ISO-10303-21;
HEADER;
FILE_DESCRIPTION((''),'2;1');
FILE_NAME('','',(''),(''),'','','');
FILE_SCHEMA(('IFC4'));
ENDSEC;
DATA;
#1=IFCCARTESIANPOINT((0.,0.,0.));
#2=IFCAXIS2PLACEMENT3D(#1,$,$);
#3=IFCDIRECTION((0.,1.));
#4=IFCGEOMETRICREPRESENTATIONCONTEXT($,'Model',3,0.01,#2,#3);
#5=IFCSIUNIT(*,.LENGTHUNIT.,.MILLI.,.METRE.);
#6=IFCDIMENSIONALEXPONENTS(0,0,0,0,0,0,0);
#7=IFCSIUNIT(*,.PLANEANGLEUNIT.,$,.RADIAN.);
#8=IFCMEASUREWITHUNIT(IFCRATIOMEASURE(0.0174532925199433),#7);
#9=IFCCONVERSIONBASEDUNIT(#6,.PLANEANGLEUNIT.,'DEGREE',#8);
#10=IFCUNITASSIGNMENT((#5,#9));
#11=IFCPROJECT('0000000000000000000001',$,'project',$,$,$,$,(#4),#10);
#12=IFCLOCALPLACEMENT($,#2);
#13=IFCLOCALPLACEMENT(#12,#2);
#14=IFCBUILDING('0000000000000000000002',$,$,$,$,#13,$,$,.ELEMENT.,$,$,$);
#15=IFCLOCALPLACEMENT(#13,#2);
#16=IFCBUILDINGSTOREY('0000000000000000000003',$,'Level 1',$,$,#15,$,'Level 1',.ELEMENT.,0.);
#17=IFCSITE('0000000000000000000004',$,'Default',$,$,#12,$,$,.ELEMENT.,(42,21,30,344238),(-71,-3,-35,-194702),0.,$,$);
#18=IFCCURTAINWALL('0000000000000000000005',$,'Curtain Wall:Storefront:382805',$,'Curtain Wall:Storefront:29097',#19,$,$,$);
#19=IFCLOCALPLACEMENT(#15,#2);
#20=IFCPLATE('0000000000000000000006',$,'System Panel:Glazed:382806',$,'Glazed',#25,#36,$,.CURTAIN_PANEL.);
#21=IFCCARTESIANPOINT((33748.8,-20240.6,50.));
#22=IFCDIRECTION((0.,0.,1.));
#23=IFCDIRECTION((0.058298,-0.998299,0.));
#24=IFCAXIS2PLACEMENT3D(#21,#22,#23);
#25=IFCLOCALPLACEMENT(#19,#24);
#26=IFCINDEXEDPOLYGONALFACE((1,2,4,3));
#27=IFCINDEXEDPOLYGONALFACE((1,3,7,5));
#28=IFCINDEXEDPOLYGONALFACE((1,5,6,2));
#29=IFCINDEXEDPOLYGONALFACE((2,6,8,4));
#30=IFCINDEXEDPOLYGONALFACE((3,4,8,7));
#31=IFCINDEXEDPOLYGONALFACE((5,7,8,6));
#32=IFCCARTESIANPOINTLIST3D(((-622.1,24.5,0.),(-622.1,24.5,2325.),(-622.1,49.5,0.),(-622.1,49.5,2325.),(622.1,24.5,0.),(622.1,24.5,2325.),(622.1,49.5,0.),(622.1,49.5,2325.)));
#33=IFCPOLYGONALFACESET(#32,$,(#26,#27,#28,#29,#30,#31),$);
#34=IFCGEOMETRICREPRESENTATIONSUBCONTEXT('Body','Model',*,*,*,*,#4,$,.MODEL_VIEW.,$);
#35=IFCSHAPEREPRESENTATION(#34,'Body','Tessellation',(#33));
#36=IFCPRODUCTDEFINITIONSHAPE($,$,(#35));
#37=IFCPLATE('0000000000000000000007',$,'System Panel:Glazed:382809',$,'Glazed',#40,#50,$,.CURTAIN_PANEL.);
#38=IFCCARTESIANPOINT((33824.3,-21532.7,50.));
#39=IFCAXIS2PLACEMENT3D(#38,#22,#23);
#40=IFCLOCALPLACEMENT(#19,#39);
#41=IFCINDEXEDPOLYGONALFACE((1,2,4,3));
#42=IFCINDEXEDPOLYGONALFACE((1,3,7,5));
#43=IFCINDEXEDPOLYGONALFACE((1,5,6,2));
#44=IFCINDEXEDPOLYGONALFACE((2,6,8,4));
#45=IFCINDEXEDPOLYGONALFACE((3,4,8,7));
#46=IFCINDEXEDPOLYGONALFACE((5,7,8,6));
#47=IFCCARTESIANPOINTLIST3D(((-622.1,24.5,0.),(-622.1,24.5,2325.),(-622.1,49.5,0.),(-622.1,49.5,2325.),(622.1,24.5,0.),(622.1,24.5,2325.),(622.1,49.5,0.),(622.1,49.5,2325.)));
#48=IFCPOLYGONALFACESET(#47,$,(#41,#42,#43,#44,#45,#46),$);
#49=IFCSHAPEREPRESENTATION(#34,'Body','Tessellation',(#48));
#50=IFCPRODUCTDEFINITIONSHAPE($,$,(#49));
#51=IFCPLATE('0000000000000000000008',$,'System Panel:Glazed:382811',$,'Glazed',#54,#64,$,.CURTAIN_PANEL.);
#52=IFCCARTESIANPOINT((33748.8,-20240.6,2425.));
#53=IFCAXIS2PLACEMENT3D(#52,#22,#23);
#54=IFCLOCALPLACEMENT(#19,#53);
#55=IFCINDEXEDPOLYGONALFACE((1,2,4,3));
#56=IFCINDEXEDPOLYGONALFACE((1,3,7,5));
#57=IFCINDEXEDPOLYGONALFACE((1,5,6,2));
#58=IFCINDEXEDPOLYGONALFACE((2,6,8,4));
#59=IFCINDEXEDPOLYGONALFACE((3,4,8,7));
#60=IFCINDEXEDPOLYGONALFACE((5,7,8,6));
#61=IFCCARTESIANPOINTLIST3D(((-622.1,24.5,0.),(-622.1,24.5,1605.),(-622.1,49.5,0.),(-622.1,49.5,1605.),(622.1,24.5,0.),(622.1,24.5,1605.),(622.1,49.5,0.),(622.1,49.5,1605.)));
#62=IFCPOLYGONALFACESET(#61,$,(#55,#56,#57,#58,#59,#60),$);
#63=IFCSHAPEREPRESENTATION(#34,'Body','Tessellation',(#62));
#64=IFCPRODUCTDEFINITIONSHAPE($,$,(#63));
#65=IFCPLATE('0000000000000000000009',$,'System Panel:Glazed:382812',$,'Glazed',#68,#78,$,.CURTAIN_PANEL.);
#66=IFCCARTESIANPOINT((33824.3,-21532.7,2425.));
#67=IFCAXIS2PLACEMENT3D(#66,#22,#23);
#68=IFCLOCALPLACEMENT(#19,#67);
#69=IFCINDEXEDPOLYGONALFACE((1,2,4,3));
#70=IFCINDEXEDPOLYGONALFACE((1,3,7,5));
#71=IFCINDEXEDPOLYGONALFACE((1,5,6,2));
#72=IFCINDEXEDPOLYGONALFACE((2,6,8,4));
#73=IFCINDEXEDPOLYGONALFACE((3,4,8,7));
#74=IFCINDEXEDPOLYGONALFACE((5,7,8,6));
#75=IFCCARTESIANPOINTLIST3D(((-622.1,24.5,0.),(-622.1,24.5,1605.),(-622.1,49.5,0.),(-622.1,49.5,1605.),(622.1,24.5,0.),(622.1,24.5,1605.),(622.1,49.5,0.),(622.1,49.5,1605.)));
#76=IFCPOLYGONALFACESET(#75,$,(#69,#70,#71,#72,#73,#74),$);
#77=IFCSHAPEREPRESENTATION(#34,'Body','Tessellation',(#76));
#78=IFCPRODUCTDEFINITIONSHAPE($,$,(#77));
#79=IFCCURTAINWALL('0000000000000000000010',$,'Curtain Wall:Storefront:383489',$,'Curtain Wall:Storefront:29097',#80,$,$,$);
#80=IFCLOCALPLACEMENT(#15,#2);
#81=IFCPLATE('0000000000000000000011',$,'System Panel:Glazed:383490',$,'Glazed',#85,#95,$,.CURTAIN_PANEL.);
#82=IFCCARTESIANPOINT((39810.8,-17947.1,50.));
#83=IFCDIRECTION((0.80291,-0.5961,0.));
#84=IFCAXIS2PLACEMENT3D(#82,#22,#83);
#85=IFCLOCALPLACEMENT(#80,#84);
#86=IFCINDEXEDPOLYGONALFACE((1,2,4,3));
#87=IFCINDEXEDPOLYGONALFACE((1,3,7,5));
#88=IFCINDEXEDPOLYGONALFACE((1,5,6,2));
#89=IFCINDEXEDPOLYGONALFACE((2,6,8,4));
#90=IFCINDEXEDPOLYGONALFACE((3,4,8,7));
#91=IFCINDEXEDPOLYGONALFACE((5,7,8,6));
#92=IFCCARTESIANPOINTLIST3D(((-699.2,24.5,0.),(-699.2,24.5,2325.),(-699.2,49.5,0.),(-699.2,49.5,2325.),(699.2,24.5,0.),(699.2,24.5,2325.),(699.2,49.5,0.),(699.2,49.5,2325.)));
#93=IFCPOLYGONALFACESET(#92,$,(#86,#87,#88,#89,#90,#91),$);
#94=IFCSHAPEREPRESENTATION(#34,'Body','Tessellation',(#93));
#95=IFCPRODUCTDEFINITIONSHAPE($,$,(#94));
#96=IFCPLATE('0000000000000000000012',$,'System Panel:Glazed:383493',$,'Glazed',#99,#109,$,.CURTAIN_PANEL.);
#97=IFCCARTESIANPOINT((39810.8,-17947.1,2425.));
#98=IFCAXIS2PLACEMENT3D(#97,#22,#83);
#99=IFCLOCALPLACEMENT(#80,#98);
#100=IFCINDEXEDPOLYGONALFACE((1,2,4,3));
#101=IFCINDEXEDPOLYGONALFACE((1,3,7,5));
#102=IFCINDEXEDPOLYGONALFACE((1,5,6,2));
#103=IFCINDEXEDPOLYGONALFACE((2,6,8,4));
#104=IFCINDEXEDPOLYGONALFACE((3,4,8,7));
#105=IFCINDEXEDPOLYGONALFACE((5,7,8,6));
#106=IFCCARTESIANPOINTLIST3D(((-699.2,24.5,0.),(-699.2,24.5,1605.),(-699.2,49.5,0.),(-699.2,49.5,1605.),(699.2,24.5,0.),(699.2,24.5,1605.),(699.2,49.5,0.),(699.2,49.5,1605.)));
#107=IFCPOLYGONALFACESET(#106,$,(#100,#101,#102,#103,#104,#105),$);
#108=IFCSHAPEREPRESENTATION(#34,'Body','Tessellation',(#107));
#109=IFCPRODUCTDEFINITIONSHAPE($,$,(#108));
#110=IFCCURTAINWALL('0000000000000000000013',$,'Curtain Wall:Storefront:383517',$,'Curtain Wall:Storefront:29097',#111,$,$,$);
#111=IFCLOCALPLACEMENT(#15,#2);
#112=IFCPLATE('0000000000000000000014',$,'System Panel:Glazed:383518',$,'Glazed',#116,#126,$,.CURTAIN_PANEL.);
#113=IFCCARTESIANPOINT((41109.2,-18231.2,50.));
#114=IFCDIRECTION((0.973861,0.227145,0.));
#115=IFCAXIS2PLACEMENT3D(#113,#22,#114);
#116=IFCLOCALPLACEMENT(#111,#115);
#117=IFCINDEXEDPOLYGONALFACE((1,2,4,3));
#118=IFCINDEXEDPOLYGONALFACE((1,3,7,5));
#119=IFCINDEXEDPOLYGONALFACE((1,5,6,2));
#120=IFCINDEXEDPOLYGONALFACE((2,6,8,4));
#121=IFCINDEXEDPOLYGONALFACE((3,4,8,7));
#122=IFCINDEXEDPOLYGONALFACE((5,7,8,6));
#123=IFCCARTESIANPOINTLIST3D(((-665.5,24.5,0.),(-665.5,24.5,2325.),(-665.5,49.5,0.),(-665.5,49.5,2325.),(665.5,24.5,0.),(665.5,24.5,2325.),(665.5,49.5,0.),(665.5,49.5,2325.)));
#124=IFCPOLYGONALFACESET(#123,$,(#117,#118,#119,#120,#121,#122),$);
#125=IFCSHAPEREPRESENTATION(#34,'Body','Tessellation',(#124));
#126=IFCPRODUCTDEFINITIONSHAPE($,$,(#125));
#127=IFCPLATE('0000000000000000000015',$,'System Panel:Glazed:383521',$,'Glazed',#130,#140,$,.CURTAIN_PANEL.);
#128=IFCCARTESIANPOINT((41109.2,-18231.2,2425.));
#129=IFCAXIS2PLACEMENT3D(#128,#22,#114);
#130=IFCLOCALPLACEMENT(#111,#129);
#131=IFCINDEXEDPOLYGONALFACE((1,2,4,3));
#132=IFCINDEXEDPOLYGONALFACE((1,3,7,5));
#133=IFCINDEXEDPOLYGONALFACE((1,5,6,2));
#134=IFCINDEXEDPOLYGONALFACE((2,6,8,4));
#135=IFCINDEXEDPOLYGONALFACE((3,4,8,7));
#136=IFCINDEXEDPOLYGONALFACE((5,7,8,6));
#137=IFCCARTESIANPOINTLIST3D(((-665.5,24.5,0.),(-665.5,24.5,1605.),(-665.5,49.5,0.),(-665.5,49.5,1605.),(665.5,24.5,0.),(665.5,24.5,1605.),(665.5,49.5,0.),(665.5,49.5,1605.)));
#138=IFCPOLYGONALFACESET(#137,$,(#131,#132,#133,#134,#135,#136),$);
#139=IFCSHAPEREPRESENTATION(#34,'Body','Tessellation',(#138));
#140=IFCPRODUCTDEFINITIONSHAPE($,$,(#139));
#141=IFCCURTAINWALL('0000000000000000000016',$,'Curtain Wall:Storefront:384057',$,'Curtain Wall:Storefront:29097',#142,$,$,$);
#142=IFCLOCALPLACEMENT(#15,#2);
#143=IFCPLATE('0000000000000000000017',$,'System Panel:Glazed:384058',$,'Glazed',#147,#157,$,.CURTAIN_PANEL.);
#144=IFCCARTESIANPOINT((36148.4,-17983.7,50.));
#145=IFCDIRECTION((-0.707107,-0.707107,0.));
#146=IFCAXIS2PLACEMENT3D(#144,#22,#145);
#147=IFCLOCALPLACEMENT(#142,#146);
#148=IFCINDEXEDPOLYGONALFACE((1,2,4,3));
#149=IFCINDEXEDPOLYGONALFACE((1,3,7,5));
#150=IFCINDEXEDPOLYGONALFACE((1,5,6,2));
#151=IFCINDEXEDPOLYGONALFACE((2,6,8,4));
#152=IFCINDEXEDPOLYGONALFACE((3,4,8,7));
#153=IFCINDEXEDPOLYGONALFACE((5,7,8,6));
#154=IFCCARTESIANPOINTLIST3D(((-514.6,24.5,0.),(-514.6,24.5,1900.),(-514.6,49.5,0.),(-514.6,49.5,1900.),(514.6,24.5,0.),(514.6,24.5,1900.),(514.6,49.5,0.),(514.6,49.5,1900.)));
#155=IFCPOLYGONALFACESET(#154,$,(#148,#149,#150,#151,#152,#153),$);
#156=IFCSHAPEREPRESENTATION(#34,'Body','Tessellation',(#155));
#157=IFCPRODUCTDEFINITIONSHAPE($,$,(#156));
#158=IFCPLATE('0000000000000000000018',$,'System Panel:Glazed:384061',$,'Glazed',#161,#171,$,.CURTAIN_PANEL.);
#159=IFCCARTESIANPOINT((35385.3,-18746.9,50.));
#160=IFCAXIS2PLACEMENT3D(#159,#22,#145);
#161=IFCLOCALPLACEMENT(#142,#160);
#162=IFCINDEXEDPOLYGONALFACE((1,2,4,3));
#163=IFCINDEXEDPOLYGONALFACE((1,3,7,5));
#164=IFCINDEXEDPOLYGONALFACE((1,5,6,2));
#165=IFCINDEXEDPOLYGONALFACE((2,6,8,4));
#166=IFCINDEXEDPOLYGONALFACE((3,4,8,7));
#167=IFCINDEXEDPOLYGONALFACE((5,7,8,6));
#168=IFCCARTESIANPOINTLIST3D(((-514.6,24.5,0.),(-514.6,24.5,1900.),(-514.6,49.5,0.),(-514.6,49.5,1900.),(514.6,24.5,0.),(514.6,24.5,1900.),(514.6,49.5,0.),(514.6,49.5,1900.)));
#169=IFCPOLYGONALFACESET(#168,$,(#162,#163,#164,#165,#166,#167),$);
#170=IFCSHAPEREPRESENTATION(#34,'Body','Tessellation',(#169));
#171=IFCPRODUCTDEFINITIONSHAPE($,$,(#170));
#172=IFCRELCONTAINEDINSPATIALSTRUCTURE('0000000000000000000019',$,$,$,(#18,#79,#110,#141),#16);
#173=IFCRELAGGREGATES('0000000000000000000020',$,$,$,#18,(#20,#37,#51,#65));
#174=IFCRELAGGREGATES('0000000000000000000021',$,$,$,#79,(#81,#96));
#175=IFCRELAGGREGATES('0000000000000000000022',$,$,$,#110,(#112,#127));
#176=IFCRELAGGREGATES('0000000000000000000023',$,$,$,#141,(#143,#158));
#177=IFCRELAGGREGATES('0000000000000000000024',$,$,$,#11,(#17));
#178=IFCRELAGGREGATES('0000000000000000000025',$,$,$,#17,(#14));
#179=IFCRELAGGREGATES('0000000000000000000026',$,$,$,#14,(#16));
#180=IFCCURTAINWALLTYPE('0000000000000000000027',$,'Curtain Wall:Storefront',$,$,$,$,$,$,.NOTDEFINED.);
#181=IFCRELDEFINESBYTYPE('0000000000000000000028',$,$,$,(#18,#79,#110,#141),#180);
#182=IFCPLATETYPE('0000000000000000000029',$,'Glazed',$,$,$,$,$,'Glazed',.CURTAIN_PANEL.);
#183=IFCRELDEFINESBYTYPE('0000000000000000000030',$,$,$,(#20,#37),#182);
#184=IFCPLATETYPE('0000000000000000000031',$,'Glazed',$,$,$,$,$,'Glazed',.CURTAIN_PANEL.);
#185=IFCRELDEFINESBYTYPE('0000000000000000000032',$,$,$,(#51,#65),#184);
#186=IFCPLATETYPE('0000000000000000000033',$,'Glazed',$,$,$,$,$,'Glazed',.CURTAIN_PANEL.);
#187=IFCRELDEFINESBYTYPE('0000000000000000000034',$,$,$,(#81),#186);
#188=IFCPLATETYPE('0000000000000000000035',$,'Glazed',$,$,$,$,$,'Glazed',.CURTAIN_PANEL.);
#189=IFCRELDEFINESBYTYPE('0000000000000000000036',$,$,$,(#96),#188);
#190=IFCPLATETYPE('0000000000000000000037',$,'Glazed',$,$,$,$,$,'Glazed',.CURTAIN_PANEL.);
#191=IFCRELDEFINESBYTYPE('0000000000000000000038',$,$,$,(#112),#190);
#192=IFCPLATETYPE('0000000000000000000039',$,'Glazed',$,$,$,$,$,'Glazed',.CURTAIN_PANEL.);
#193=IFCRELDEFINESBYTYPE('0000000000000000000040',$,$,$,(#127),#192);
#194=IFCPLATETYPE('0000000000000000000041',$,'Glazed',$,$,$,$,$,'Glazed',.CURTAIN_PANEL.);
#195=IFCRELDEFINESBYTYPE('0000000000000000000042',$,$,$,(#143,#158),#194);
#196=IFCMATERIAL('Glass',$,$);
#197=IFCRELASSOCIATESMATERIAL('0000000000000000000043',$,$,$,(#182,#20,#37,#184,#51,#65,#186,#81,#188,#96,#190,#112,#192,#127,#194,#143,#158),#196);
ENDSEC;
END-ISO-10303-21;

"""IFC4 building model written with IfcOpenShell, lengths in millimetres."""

from ifc_helpers import new_model, entity, si_unit, converted_unit, direction, frame, frame_2d, origin, place, context, subcontext, project, spatial, rectangle, extrude, source, transform, mapped, material, type_object, type_shapes, element, aggregate, save


model = new_model("IFC4")

# Units and contexts
model_context = context("Model", 3, precision=0.01, world=origin(), true_north=direction((0.0, 1.0)))
body_context = subcontext(model_context, "Body", "Model", "MODEL_VIEW")
ifc_project = project(units=[si_unit("LENGTHUNIT", "METRE", prefix="MILLI"), converted_unit("PLANEANGLEUNIT", "DEGREE", entity("IfcRatioMeasure", 0.0174532925199433), si_unit("PLANEANGLEUNIT", "RADIAN"), dimensions=[0, 0, 0, 0, 0, 0, 0])], contexts=[model_context])

# Site, building, storey
site_placement = place(None, origin())
site = spatial("IfcSite", under=ifc_project, at=site_placement, Name="Default", CompositionType="ELEMENT", RefLatitude=(42, 21, 30, 344238), RefLongitude=(-71, -3, -35, -194702), RefElevation=0.0)
building_placement = place(site_placement, origin())
building = spatial("IfcBuilding", under=site, at=building_placement, CompositionType="ELEMENT")
storey_placement = place(building_placement, origin())
storey = spatial("IfcBuildingStorey", under=building, at=storey_placement, Name="Level 1", LongName="Level 1", CompositionType="ELEMENT", Elevation=0.0)

# Curtain walls, plates
curtain_wall_type = type_object("IfcCurtainWallType", Name="Curtain Wall:Storefront", PredefinedType="NOTDEFINED")
curtain_wall_1_placement = place(storey_placement, origin())
curtain_wall_1 = element("IfcCurtainWall", 1, at=curtain_wall_1_placement, inside=storey, type_object=curtain_wall_type, Name="Curtain Wall:Storefront:382805", ObjectType="Curtain Wall:Storefront:29097")
ifc_material_1 = material(Name="Glass")
plate_type_1 = type_object("IfcPlateType", Name="Glazed", ElementType="Glazed", PredefinedType="CURTAIN_PANEL", material=ifc_material_1)
shared_shape_1 = source(origin(), body_context, "Body", "SweptSolid", [
    extrude(rectangle(XDim=25.0, YDim=1244.2, at=frame_2d((0.0, 0.0), x_axis=(1.0, 0.0))), frame((0.0, 37.0, 0.0), z_axis=(0.0, 0.0, 1.0), x_axis=(0.0, 1.0, 0.0)), (0.0, 0.0, 1.0), 2325.0),
])
type_shapes(plate_type_1, [shared_shape_1])
plate_1_placement = place(curtain_wall_1_placement, frame((33748.8, -20240.6, 50.0), z_axis=(0.0, 0.0, 1.0), x_axis=(0.058298, -0.998299, 0.0)))
plate_1 = element("IfcPlate", 2, at=plate_1_placement, type_object=plate_type_1, material=ifc_material_1, Name="System Panel:Glazed:382806", ObjectType="Glazed", PredefinedType="CURTAIN_PANEL", context=body_context, shape_type="MappedRepresentation", body=[
    mapped(shared_shape_1, transform((0.0, 0.0, 0.0), scale=1.0)),
])
plate_2_placement = place(curtain_wall_1_placement, frame((33824.3, -21532.7, 50.0), z_axis=(0.0, 0.0, 1.0), x_axis=(0.058298, -0.998299, 0.0)))
plate_2 = element("IfcPlate", 3, at=plate_2_placement, type_object=plate_type_1, material=ifc_material_1, Name="System Panel:Glazed:382809", ObjectType="Glazed", PredefinedType="CURTAIN_PANEL", context=body_context, shape_type="MappedRepresentation", body=[
    mapped(shared_shape_1, transform((0.0, 0.0, 0.0), scale=1.0)),
])
plate_type_2 = type_object("IfcPlateType", Name="Glazed", ElementType="Glazed", PredefinedType="CURTAIN_PANEL", material=ifc_material_1)
shared_shape_2 = source(origin(), body_context, "Body", "SweptSolid", [
    extrude(rectangle(XDim=25.0, YDim=1244.2, at=frame_2d((0.0, 0.0), x_axis=(1.0, 0.0))), frame((0.0, 37.0, 0.0), z_axis=(0.0, 0.0, 1.0), x_axis=(0.0, 1.0, 0.0)), (0.0, 0.0, 1.0), 1605.0),
])
type_shapes(plate_type_2, [shared_shape_2])
plate_3_placement = place(curtain_wall_1_placement, frame((33748.8, -20240.6, 2425.0), z_axis=(0.0, 0.0, 1.0), x_axis=(0.058298, -0.998299, 0.0)))
plate_3 = element("IfcPlate", 4, at=plate_3_placement, type_object=plate_type_2, material=ifc_material_1, Name="System Panel:Glazed:382811", ObjectType="Glazed", PredefinedType="CURTAIN_PANEL", context=body_context, shape_type="MappedRepresentation", body=[
    mapped(shared_shape_2, transform((0.0, 0.0, 0.0), scale=1.0)),
])
plate_4_placement = place(curtain_wall_1_placement, frame((33824.3, -21532.7, 2425.0), z_axis=(0.0, 0.0, 1.0), x_axis=(0.058298, -0.998299, 0.0)))
plate_4 = element("IfcPlate", 5, at=plate_4_placement, type_object=plate_type_2, material=ifc_material_1, Name="System Panel:Glazed:382812", ObjectType="Glazed", PredefinedType="CURTAIN_PANEL", context=body_context, shape_type="MappedRepresentation", body=[
    mapped(shared_shape_2, transform((0.0, 0.0, 0.0), scale=1.0)),
])
aggregate(curtain_wall_1, [plate_1, plate_2, plate_3, plate_4])
curtain_wall_2_placement = place(storey_placement, origin())
curtain_wall_2 = element("IfcCurtainWall", 6, at=curtain_wall_2_placement, inside=storey, type_object=curtain_wall_type, Name="Curtain Wall:Storefront:383489", ObjectType="Curtain Wall:Storefront:29097")
plate_type_3 = type_object("IfcPlateType", Name="Glazed", ElementType="Glazed", PredefinedType="CURTAIN_PANEL", material=ifc_material_1)
shared_shape_3 = source(origin(), body_context, "Body", "SweptSolid", [
    extrude(rectangle(XDim=25.0, YDim=1398.4, at=frame_2d((0.0, 0.0), x_axis=(1.0, 0.0))), frame((0.0, 37.0, 0.0), z_axis=(0.0, 0.0, 1.0), x_axis=(0.0, 1.0, 0.0)), (0.0, 0.0, 1.0), 2325.0),
])
type_shapes(plate_type_3, [shared_shape_3])
plate_5_placement = place(curtain_wall_2_placement, frame((39810.8, -17947.1, 50.0), z_axis=(0.0, 0.0, 1.0), x_axis=(0.80291, -0.5961, 0.0)))
plate_5 = element("IfcPlate", 7, at=plate_5_placement, type_object=plate_type_3, material=ifc_material_1, Name="System Panel:Glazed:383490", ObjectType="Glazed", PredefinedType="CURTAIN_PANEL", context=body_context, shape_type="MappedRepresentation", body=[
    mapped(shared_shape_3, transform((0.0, 0.0, 0.0), scale=1.0)),
])
plate_type_4 = type_object("IfcPlateType", Name="Glazed", ElementType="Glazed", PredefinedType="CURTAIN_PANEL", material=ifc_material_1)
shared_shape_4 = source(origin(), body_context, "Body", "SweptSolid", [
    extrude(rectangle(XDim=25.0, YDim=1398.4, at=frame_2d((0.0, 0.0), x_axis=(1.0, 0.0))), frame((0.0, 37.0, 0.0), z_axis=(0.0, 0.0, 1.0), x_axis=(0.0, 1.0, 0.0)), (0.0, 0.0, 1.0), 1605.0),
])
type_shapes(plate_type_4, [shared_shape_4])
plate_6_placement = place(curtain_wall_2_placement, frame((39810.8, -17947.1, 2425.0), z_axis=(0.0, 0.0, 1.0), x_axis=(0.80291, -0.5961, 0.0)))
plate_6 = element("IfcPlate", 8, at=plate_6_placement, type_object=plate_type_4, material=ifc_material_1, Name="System Panel:Glazed:383493", ObjectType="Glazed", PredefinedType="CURTAIN_PANEL", context=body_context, shape_type="MappedRepresentation", body=[
    mapped(shared_shape_4, transform((0.0, 0.0, 0.0), scale=1.0)),
])
aggregate(curtain_wall_2, [plate_5, plate_6])
curtain_wall_3_placement = place(storey_placement, origin())
curtain_wall_3 = element("IfcCurtainWall", 9, at=curtain_wall_3_placement, inside=storey, type_object=curtain_wall_type, Name="Curtain Wall:Storefront:383517", ObjectType="Curtain Wall:Storefront:29097")
plate_type_5 = type_object("IfcPlateType", Name="Glazed", ElementType="Glazed", PredefinedType="CURTAIN_PANEL", material=ifc_material_1)
shared_shape_5 = source(origin(), body_context, "Body", "SweptSolid", [
    extrude(rectangle(XDim=25.0, YDim=1331.1, at=frame_2d((0.0, 0.0), x_axis=(1.0, 0.0))), frame((0.0, 37.0, 0.0), z_axis=(0.0, 0.0, 1.0), x_axis=(0.0, 1.0, 0.0)), (0.0, 0.0, 1.0), 2325.0),
])
type_shapes(plate_type_5, [shared_shape_5])
plate_7_placement = place(curtain_wall_3_placement, frame((41109.2, -18231.2, 50.0), z_axis=(0.0, 0.0, 1.0), x_axis=(0.973861, 0.227145, 0.0)))
plate_7 = element("IfcPlate", 10, at=plate_7_placement, type_object=plate_type_5, material=ifc_material_1, Name="System Panel:Glazed:383518", ObjectType="Glazed", PredefinedType="CURTAIN_PANEL", context=body_context, shape_type="MappedRepresentation", body=[
    mapped(shared_shape_5, transform((0.0, 0.0, 0.0), scale=1.0)),
])
plate_type_6 = type_object("IfcPlateType", Name="Glazed", ElementType="Glazed", PredefinedType="CURTAIN_PANEL", material=ifc_material_1)
shared_shape_6 = source(origin(), body_context, "Body", "SweptSolid", [
    extrude(rectangle(XDim=25.0, YDim=1331.1, at=frame_2d((0.0, 0.0), x_axis=(1.0, 0.0))), frame((0.0, 37.0, 0.0), z_axis=(0.0, 0.0, 1.0), x_axis=(0.0, 1.0, 0.0)), (0.0, 0.0, 1.0), 1605.0),
])
type_shapes(plate_type_6, [shared_shape_6])
plate_8_placement = place(curtain_wall_3_placement, frame((41109.2, -18231.2, 2425.0), z_axis=(0.0, 0.0, 1.0), x_axis=(0.973861, 0.227145, 0.0)))
plate_8 = element("IfcPlate", 11, at=plate_8_placement, type_object=plate_type_6, material=ifc_material_1, Name="System Panel:Glazed:383521", ObjectType="Glazed", PredefinedType="CURTAIN_PANEL", context=body_context, shape_type="MappedRepresentation", body=[
    mapped(shared_shape_6, transform((0.0, 0.0, 0.0), scale=1.0)),
])
aggregate(curtain_wall_3, [plate_7, plate_8])
curtain_wall_4_placement = place(storey_placement, origin())
curtain_wall_4 = element("IfcCurtainWall", 12, at=curtain_wall_4_placement, inside=storey, type_object=curtain_wall_type, Name="Curtain Wall:Storefront:384057", ObjectType="Curtain Wall:Storefront:29097")
plate_type_7 = type_object("IfcPlateType", Name="Glazed", ElementType="Glazed", PredefinedType="CURTAIN_PANEL", material=ifc_material_1)
shared_shape_7 = source(origin(), body_context, "Body", "SweptSolid", [
    extrude(rectangle(XDim=25.0, YDim=1029.3, at=frame_2d((0.0, 0.0), x_axis=(1.0, 0.0))), frame((0.0, 37.0, 0.0), z_axis=(0.0, 0.0, 1.0), x_axis=(0.0, 1.0, 0.0)), (0.0, 0.0, 1.0), 1900.0),
])
type_shapes(plate_type_7, [shared_shape_7])
plate_9_placement = place(curtain_wall_4_placement, frame((36148.4, -17983.7, 50.0), z_axis=(0.0, 0.0, 1.0), x_axis=(-0.707107, -0.707107, 0.0)))
plate_9 = element("IfcPlate", 13, at=plate_9_placement, type_object=plate_type_7, material=ifc_material_1, Name="System Panel:Glazed:384058", ObjectType="Glazed", PredefinedType="CURTAIN_PANEL", context=body_context, shape_type="MappedRepresentation", body=[
    mapped(shared_shape_7, transform((0.0, 0.0, 0.0), scale=1.0)),
])
plate_10_placement = place(curtain_wall_4_placement, frame((35385.3, -18746.9, 50.0), z_axis=(0.0, 0.0, 1.0), x_axis=(-0.707107, -0.707107, 0.0)))
plate_10 = element("IfcPlate", 14, at=plate_10_placement, type_object=plate_type_7, material=ifc_material_1, Name="System Panel:Glazed:384061", ObjectType="Glazed", PredefinedType="CURTAIN_PANEL", context=body_context, shape_type="MappedRepresentation", body=[
    mapped(shared_shape_7, transform((0.0, 0.0, 0.0), scale=1.0)),
])
aggregate(curtain_wall_4, [plate_9, plate_10])

save(model, "model.ifc")
